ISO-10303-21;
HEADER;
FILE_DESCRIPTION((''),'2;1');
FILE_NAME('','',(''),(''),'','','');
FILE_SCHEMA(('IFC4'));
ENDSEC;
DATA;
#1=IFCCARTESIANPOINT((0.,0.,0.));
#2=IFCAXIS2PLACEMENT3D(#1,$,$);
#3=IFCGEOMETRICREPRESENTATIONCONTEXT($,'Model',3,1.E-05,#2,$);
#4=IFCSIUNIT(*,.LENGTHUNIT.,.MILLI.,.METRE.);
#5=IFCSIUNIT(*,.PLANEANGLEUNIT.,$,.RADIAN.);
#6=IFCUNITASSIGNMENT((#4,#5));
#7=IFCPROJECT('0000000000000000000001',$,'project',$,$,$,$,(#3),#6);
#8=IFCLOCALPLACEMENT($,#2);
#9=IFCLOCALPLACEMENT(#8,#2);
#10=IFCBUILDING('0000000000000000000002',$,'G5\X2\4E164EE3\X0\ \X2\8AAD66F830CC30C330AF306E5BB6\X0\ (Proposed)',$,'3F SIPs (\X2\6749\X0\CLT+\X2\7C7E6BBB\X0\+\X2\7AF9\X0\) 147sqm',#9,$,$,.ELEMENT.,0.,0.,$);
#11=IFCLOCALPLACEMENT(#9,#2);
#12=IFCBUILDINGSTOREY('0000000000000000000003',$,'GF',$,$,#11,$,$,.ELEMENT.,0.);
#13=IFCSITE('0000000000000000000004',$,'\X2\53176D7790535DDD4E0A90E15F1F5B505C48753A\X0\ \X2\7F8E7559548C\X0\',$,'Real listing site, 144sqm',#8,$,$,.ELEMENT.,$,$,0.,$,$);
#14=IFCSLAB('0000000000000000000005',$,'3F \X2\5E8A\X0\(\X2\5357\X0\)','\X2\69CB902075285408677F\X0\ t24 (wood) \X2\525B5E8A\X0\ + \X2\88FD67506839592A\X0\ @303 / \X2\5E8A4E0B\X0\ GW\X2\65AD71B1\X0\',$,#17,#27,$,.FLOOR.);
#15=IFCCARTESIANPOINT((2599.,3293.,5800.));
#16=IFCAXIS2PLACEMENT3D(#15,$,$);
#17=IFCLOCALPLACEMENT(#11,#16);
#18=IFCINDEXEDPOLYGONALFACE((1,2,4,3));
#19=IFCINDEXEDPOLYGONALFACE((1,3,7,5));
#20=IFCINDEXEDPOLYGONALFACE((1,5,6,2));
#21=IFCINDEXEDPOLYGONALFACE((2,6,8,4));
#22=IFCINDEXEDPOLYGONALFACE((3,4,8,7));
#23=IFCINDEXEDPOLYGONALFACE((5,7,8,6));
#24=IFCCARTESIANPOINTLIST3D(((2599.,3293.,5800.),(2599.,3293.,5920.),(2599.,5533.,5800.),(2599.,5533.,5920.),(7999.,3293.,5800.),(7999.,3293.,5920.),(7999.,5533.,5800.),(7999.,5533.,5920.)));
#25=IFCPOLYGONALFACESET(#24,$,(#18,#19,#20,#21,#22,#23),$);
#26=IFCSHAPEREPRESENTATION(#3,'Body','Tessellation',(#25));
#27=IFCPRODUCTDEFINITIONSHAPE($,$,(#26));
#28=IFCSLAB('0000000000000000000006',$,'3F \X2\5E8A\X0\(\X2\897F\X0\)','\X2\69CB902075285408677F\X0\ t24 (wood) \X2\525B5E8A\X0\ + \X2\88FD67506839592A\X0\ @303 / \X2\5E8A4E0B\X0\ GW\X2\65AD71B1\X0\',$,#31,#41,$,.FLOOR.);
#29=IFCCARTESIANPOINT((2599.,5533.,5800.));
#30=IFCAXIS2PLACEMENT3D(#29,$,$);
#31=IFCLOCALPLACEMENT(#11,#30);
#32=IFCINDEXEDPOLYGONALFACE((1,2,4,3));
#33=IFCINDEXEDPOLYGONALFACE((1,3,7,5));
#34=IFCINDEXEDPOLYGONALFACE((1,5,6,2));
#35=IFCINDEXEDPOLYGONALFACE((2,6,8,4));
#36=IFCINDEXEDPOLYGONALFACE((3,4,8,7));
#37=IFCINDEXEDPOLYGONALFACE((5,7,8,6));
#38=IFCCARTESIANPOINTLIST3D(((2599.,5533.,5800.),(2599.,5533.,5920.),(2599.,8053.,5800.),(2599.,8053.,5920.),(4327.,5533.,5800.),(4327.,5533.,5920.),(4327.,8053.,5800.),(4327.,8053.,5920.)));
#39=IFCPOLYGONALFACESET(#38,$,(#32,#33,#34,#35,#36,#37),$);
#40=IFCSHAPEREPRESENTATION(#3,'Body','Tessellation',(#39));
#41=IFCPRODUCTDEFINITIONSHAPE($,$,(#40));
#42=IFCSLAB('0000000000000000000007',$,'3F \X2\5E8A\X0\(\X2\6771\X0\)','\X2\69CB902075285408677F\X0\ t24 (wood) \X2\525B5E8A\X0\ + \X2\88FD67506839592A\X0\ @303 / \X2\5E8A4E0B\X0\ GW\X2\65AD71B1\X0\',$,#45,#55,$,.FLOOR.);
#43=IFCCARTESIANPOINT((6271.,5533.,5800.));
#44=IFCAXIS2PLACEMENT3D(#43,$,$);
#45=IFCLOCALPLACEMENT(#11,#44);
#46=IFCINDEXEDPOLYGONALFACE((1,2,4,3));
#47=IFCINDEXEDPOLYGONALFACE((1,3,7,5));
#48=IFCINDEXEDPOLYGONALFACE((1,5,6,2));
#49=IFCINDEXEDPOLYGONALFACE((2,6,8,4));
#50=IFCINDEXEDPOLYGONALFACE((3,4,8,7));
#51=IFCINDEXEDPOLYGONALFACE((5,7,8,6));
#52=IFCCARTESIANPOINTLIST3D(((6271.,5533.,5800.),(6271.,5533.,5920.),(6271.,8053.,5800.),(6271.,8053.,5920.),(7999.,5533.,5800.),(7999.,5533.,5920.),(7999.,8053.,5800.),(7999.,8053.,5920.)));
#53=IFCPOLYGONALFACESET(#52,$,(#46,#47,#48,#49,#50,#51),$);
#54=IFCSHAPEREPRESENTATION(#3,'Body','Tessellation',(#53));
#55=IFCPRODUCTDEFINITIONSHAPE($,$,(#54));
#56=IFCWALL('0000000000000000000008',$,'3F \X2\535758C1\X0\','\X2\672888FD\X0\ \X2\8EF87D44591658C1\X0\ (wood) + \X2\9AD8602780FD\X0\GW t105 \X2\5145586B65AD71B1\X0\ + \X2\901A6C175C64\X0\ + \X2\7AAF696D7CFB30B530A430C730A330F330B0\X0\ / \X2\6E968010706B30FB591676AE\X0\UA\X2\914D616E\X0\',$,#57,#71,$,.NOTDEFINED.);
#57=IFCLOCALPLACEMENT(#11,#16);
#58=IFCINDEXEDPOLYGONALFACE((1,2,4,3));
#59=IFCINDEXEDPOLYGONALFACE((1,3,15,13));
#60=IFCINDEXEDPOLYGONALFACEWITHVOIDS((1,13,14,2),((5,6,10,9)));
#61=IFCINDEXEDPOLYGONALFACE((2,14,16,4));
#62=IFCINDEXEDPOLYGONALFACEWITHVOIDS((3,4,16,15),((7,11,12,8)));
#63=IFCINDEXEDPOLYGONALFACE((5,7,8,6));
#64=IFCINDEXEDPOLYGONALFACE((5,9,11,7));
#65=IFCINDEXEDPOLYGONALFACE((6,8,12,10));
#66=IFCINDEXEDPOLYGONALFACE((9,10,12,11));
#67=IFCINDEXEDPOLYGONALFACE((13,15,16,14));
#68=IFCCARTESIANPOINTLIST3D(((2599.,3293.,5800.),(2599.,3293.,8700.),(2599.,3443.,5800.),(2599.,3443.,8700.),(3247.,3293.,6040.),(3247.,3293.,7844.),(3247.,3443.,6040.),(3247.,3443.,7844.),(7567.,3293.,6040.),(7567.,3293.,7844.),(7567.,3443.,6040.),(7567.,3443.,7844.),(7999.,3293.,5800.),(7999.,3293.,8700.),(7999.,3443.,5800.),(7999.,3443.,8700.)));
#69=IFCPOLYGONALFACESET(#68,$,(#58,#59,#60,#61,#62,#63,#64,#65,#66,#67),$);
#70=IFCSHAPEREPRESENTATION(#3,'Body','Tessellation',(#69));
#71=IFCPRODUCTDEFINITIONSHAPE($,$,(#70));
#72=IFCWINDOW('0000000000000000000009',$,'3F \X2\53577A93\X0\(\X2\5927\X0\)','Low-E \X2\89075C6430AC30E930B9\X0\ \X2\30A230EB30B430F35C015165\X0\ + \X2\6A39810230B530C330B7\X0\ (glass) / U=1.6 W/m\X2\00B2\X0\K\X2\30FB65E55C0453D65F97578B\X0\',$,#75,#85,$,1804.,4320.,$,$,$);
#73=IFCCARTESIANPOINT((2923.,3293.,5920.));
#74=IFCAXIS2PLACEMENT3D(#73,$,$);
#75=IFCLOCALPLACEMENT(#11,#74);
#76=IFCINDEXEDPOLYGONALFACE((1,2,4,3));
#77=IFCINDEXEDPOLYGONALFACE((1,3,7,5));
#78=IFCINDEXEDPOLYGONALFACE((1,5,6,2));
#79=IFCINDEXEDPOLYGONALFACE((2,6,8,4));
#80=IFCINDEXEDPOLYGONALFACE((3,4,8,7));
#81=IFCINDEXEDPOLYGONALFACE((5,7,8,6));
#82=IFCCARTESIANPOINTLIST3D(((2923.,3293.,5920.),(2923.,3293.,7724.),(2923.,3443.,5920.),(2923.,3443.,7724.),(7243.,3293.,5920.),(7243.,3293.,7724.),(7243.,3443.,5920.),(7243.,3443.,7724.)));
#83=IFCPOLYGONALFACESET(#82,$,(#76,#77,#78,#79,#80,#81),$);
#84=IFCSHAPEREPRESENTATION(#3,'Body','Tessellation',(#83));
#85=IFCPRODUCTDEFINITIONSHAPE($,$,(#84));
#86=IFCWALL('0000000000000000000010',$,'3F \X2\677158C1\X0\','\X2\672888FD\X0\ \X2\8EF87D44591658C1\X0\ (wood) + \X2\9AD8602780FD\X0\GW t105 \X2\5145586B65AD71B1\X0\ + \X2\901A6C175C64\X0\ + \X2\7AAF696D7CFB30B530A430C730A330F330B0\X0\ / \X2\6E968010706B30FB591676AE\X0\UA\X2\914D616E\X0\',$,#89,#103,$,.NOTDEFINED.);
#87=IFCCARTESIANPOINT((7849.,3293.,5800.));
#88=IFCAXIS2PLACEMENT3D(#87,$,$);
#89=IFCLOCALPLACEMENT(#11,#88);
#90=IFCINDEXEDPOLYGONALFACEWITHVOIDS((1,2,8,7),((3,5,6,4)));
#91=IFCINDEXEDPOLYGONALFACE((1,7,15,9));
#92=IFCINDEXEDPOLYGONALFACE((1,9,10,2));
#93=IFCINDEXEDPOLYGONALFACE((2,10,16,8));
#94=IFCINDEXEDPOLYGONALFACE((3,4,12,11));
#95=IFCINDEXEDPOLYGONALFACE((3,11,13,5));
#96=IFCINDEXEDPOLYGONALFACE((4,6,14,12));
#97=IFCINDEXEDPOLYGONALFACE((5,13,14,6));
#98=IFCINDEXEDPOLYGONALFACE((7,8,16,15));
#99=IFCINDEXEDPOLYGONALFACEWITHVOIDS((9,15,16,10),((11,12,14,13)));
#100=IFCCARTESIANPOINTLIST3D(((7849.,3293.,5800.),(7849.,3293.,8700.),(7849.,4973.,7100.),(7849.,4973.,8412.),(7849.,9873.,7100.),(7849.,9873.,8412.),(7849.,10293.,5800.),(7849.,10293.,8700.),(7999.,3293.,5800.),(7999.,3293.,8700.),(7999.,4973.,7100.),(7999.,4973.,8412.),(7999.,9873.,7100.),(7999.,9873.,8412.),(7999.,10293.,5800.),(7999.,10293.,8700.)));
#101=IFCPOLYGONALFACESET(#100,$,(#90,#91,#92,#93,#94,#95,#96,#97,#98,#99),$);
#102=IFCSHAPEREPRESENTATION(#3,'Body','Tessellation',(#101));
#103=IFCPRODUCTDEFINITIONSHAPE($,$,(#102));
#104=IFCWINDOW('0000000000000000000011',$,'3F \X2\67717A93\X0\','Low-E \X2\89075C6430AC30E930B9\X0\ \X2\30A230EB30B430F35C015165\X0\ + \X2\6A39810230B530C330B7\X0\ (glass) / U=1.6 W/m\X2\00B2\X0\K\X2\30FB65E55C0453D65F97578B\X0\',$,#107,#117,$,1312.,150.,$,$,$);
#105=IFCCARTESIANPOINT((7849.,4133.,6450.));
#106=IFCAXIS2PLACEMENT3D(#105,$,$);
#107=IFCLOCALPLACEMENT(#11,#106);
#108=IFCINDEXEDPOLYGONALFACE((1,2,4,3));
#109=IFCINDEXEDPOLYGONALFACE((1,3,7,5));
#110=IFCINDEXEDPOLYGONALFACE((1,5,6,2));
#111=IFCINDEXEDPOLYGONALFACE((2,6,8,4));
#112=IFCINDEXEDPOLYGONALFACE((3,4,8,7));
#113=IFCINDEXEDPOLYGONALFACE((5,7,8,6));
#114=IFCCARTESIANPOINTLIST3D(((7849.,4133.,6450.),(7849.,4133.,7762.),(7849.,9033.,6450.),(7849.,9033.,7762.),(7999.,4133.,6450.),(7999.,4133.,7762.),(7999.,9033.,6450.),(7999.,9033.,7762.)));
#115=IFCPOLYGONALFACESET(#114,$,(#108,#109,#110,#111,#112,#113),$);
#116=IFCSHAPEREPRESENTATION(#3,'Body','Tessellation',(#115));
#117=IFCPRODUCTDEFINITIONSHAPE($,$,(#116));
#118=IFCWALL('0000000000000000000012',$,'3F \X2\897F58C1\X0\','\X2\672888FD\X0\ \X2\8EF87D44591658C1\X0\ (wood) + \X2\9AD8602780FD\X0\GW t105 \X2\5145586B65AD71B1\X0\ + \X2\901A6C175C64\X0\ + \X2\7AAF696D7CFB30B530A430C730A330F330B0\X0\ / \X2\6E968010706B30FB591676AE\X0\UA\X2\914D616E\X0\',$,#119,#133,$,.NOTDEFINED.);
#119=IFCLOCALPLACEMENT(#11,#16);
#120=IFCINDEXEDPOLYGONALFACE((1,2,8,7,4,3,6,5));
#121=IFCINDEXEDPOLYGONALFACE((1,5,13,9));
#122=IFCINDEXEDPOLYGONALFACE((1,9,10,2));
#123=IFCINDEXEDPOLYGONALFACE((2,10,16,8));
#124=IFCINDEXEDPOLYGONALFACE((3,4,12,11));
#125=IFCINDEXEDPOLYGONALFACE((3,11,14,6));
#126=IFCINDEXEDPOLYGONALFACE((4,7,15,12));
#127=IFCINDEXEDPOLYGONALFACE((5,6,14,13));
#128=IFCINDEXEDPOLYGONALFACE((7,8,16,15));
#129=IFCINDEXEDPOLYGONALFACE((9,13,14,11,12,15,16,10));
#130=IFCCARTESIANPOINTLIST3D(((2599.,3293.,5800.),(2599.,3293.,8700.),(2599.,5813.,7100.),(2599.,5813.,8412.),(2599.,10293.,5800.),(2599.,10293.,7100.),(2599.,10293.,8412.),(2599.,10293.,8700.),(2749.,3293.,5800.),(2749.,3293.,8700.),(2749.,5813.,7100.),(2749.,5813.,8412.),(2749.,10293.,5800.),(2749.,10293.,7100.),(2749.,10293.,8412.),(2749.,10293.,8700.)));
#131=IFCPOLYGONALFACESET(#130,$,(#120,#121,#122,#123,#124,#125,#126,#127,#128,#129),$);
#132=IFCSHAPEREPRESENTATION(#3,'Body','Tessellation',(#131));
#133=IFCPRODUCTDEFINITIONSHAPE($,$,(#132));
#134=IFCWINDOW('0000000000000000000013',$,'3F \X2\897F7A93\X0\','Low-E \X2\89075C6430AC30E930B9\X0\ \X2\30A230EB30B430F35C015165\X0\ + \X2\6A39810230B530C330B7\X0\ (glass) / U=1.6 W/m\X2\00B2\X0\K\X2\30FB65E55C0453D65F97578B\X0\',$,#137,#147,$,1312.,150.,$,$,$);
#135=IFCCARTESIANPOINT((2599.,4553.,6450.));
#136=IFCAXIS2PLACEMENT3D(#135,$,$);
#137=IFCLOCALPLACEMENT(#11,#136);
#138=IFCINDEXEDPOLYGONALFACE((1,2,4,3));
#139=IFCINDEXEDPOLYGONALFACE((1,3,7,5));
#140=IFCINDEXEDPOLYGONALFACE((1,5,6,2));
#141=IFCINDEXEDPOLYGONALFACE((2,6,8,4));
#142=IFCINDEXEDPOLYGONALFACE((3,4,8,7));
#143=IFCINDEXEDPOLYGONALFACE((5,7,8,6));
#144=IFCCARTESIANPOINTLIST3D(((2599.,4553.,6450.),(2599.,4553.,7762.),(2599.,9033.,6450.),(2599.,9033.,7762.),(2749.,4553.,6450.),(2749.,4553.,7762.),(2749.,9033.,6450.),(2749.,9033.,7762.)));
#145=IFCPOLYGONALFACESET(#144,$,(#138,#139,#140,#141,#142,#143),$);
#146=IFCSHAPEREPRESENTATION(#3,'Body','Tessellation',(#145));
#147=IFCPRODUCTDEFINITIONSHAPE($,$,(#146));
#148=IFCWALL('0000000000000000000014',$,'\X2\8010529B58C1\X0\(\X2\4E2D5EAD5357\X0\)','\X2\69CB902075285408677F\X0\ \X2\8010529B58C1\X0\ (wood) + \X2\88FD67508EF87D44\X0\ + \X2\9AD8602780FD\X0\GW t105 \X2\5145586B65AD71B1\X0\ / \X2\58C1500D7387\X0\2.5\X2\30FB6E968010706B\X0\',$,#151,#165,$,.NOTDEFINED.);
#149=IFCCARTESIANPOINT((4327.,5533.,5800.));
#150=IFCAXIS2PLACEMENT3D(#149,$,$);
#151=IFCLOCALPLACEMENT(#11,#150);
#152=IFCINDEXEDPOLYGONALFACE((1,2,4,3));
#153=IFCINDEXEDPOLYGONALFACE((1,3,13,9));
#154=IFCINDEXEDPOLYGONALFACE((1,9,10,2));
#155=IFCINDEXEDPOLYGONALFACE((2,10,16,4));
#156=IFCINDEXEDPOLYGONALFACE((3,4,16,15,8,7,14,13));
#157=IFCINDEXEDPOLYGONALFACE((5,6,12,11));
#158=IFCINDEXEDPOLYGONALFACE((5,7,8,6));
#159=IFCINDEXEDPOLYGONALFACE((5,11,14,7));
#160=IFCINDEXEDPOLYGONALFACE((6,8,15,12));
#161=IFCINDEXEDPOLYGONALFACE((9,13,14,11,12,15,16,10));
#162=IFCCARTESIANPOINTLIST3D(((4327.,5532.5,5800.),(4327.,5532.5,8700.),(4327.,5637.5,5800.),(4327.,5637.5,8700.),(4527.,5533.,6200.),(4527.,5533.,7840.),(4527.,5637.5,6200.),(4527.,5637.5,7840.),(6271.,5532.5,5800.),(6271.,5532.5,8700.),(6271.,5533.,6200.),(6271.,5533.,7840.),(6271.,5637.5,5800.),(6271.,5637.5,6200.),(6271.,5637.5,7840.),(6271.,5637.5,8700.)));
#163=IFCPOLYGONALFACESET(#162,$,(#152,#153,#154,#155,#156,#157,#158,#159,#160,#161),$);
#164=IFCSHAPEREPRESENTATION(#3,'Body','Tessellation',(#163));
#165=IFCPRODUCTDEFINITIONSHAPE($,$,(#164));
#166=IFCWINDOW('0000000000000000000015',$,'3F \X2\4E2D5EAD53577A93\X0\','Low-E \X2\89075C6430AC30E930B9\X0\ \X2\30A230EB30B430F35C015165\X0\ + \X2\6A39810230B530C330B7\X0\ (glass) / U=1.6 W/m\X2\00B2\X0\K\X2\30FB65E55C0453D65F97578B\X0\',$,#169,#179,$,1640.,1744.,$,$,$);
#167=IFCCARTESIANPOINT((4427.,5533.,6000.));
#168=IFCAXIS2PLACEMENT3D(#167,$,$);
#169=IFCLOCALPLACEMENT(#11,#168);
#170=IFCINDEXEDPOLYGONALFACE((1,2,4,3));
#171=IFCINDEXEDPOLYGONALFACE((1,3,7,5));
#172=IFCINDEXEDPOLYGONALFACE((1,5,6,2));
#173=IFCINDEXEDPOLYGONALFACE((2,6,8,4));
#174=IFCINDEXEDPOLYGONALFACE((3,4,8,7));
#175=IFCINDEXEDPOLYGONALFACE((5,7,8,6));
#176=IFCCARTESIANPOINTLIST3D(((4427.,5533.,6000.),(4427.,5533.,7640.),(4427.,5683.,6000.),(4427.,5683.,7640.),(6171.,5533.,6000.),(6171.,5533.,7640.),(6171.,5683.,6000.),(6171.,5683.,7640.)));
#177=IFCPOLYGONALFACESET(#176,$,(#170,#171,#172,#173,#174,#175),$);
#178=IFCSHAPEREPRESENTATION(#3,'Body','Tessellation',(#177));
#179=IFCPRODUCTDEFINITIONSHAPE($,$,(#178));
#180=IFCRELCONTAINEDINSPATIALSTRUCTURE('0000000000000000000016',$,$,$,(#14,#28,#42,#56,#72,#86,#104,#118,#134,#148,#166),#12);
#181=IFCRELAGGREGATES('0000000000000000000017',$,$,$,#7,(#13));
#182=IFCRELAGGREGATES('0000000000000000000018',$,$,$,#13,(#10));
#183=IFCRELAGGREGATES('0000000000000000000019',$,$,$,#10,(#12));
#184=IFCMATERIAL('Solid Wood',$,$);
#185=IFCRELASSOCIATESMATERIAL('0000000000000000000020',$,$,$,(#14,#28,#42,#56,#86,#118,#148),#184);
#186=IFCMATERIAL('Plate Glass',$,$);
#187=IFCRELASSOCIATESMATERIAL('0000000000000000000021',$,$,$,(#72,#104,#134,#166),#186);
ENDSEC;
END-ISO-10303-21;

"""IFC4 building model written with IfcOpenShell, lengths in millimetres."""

from ifc_helpers import new_model, si_unit, frame, frame_2d, origin, place, context, project, spatial, rectangle, extrude, material, element, fill, save


model = new_model("IFC4")

# Units and contexts
model_context = context("Model", 3, precision=1e-05, world=origin())
ifc_project = project(units=[si_unit("LENGTHUNIT", "METRE", prefix="MILLI"), si_unit("PLANEANGLEUNIT", "RADIAN")], contexts=[model_context])

# Site, building, storey
site_placement = place(None, origin())
site = spatial("IfcSite", under=ifc_project, at=site_placement, Name="北海道川上郡弟子屈町 美留和", ObjectType="Real listing site, 144sqm", CompositionType="ELEMENT", RefElevation=0.0)
building_placement = place(site_placement, origin())
building = spatial("IfcBuilding", under=site, at=building_placement, Name="G5世代 読書ヌックの家 (Proposed)", ObjectType="3F SIPs (杉CLT+籾殻+竹) 147sqm", CompositionType="ELEMENT", ElevationOfRefHeight=0.0, ElevationOfTerrain=0.0)
storey_placement = place(building_placement, origin())
storey = spatial("IfcBuildingStorey", under=building, at=storey_placement, Name="GF", CompositionType="ELEMENT", Elevation=0.0)

# Slabs
ifc_material_1 = material(Name="Solid Wood")
slab_1_placement = place(storey_placement, frame((2599.0, 3293.0, 5800.0)))
element("IfcSlab", 1, at=slab_1_placement, inside=storey, material=ifc_material_1, Name="3F 床(南)", Description="構造用合板 t24 (wood) 剛床 + 製材根太 @303 / 床下 GW断熱", PredefinedType="FLOOR", context=model_context, shape_type="SweptSolid", body=[
    extrude(rectangle(XDim=5400.0, YDim=2240.0, at=frame_2d((2700.0, 1120.0))), frame((2599.0, 3293.0, 5800.0)), (0.0, 0.0, 1.0), 120.0),
])
slab_2_placement = place(storey_placement, frame((2599.0, 5533.0, 5800.0)))
element("IfcSlab", 2, at=slab_2_placement, inside=storey, material=ifc_material_1, Name="3F 床(西)", Description="構造用合板 t24 (wood) 剛床 + 製材根太 @303 / 床下 GW断熱", PredefinedType="FLOOR", context=model_context, shape_type="SweptSolid", body=[
    extrude(rectangle(XDim=1728.0, YDim=2520.0, at=frame_2d((864.0, 1260.0))), frame((2599.0, 5533.0, 5800.0)), (0.0, 0.0, 1.0), 120.0),
])
slab_3_placement = place(storey_placement, frame((6271.0, 5533.0, 5800.0)))
element("IfcSlab", 3, at=slab_3_placement, inside=storey, material=ifc_material_1, Name="3F 床(東)", Description="構造用合板 t24 (wood) 剛床 + 製材根太 @303 / 床下 GW断熱", PredefinedType="FLOOR", context=model_context, shape_type="SweptSolid", body=[
    extrude(rectangle(XDim=1728.0, YDim=2520.0, at=frame_2d((864.0, 1260.0))), frame((6271.0, 5533.0, 5800.0)), (0.0, 0.0, 1.0), 120.0),
])

# Walls, openings, windows
wall_1_placement = place(storey_placement, frame((2599.0, 3293.0, 5800.0)))
wall_1 = element("IfcWall", 4, at=wall_1_placement, inside=storey, material=ifc_material_1, Name="3F 南壁", Description="木製 軸組外壁 (wood) + 高性能GW t105 充填断熱 + 通気層 + 窯業系サイディング / 準耐火・外皮UA配慮", PredefinedType="NOTDEFINED", context=model_context, shape_type="SweptSolid", body=[
    extrude(rectangle(XDim=5400.0, YDim=150.0, at=frame_2d((2700.0, 75.0))), frame((2599.0, 3293.0, 5800.0)), (0.0, 0.0, 1.0), 2900.0),
])
opening_1_placement = place(storey_placement, frame((2923.0, 3293.0, 5920.0)))
opening_1 = element("IfcOpeningElement", 5, at=opening_1_placement, cuts=wall_1, PredefinedType="NOTDEFINED", context=model_context, shape_type="SweptSolid", body=[
    extrude(rectangle(XDim=4320.0, YDim=150.0, at=frame_2d((2160.0, 75.0))), frame((2923.0, 3293.0, 5920.0)), (0.0, 0.0, 1.0), 1804.0),
])
ifc_material_2 = material(Name="Plate Glass")
window_1_placement = place(storey_placement, frame((2923.0, 3293.0, 5920.0)))
window_1 = element("IfcWindow", 6, at=window_1_placement, inside=storey, material=ifc_material_2, Name="3F 南窓(大)", Description="Low-E 複層ガラス アルゴン封入 + 樹脂サッシ (glass) / U=1.6 W/m²K・日射取得型", OverallHeight=1804.0, OverallWidth=4320.0, context=model_context, shape_type="SweptSolid", body=[
    extrude(rectangle(XDim=4320.0, YDim=150.0, at=frame_2d((2160.0, 75.0))), frame((2923.0, 3293.0, 5920.0)), (0.0, 0.0, 1.0), 1804.0),
])
fill(opening_1, window_1)
wall_2_placement = place(storey_placement, frame((7849.0, 3293.0, 5800.0)))
wall_2 = element("IfcWall", 7, at=wall_2_placement, inside=storey, material=ifc_material_1, Name="3F 東壁", Description="木製 軸組外壁 (wood) + 高性能GW t105 充填断熱 + 通気層 + 窯業系サイディング / 準耐火・外皮UA配慮", PredefinedType="NOTDEFINED", context=model_context, shape_type="SweptSolid", body=[
    extrude(rectangle(XDim=150.0, YDim=7000.0, at=frame_2d((75.0, 3500.0))), frame((7849.0, 3293.0, 5800.0)), (0.0, 0.0, 1.0), 2900.0),
])
opening_2_placement = place(storey_placement, frame((7849.0, 4133.0, 6450.0)))
opening_2 = element("IfcOpeningElement", 8, at=opening_2_placement, cuts=wall_2, PredefinedType="NOTDEFINED", context=model_context, shape_type="SweptSolid", body=[
    extrude(rectangle(XDim=150.0, YDim=4900.0, at=frame_2d((75.0, 2450.0))), frame((7849.0, 4133.0, 6450.0)), (0.0, 0.0, 1.0), 1312.0),
])
window_2_placement = place(storey_placement, frame((7849.0, 4133.0, 6450.0)))
window_2 = element("IfcWindow", 9, at=window_2_placement, inside=storey, material=ifc_material_2, Name="3F 東窓", Description="Low-E 複層ガラス アルゴン封入 + 樹脂サッシ (glass) / U=1.6 W/m²K・日射取得型", OverallHeight=1312.0, OverallWidth=150.0, context=model_context, shape_type="SweptSolid", body=[
    extrude(rectangle(XDim=150.0, YDim=4900.0, at=frame_2d((75.0, 2450.0))), frame((7849.0, 4133.0, 6450.0)), (0.0, 0.0, 1.0), 1312.0),
])
fill(opening_2, window_2)
wall_3_placement = place(storey_placement, frame((2599.0, 3293.0, 5800.0)))
wall_3 = element("IfcWall", 10, at=wall_3_placement, inside=storey, material=ifc_material_1, Name="3F 西壁", Description="木製 軸組外壁 (wood) + 高性能GW t105 充填断熱 + 通気層 + 窯業系サイディング / 準耐火・外皮UA配慮", PredefinedType="NOTDEFINED", context=model_context, shape_type="SweptSolid", body=[
    extrude(rectangle(XDim=150.0, YDim=7000.0, at=frame_2d((75.0, 3500.0))), frame((2599.0, 3293.0, 5800.0)), (0.0, 0.0, 1.0), 2900.0),
])
opening_3_placement = place(storey_placement, frame((2599.0, 4553.0, 6450.0)))
opening_3 = element("IfcOpeningElement", 11, at=opening_3_placement, cuts=wall_3, PredefinedType="NOTDEFINED", context=model_context, shape_type="SweptSolid", body=[
    extrude(rectangle(XDim=150.0, YDim=4480.0, at=frame_2d((75.0, 2240.0))), frame((2599.0, 4553.0, 6450.0)), (0.0, 0.0, 1.0), 1312.0),
])
window_3_placement = place(storey_placement, frame((2599.0, 4553.0, 6450.0)))
window_3 = element("IfcWindow", 12, at=window_3_placement, inside=storey, material=ifc_material_2, Name="3F 西窓", Description="Low-E 複層ガラス アルゴン封入 + 樹脂サッシ (glass) / U=1.6 W/m²K・日射取得型", OverallHeight=1312.0, OverallWidth=150.0, context=model_context, shape_type="SweptSolid", body=[
    extrude(rectangle(XDim=150.0, YDim=4480.0, at=frame_2d((75.0, 2240.0))), frame((2599.0, 4553.0, 6450.0)), (0.0, 0.0, 1.0), 1312.0),
])
fill(opening_3, window_3)
wall_4_placement = place(storey_placement, frame((4327.0, 5533.0, 5800.0)))
wall_4 = element("IfcWall", 13, at=wall_4_placement, inside=storey, material=ifc_material_1, Name="耐力壁(中庭南)", Description="構造用合板 耐力壁 (wood) + 製材軸組 + 高性能GW t105 充填断熱 / 壁倍率2.5・準耐火", PredefinedType="NOTDEFINED", context=model_context, shape_type="SweptSolid", body=[
    extrude(rectangle(XDim=1944.0, YDim=105.0, at=frame_2d((972.0, 52.0))), frame((4327.0, 5533.0, 5800.0)), (0.0, 0.0, 1.0), 2900.0),
])
opening_4_placement = place(storey_placement, frame((4427.0, 5533.0, 6000.0)))
opening_4 = element("IfcOpeningElement", 14, at=opening_4_placement, cuts=wall_4, PredefinedType="NOTDEFINED", context=model_context, shape_type="SweptSolid", body=[
    extrude(rectangle(XDim=1744.0, YDim=150.0, at=frame_2d((872.0, 75.0))), frame((4427.0, 5533.0, 6000.0)), (0.0, 0.0, 1.0), 1640.0),
])
window_4_placement = place(storey_placement, frame((4427.0, 5533.0, 6000.0)))
window_4 = element("IfcWindow", 15, at=window_4_placement, inside=storey, material=ifc_material_2, Name="3F 中庭南窓", Description="Low-E 複層ガラス アルゴン封入 + 樹脂サッシ (glass) / U=1.6 W/m²K・日射取得型", OverallHeight=1640.0, OverallWidth=1744.0, context=model_context, shape_type="SweptSolid", body=[
    extrude(rectangle(XDim=1744.0, YDim=150.0, at=frame_2d((872.0, 75.0))), frame((4427.0, 5533.0, 6000.0)), (0.0, 0.0, 1.0), 1640.0),
])
fill(opening_4, window_4)

save(model, "model.ifc")
